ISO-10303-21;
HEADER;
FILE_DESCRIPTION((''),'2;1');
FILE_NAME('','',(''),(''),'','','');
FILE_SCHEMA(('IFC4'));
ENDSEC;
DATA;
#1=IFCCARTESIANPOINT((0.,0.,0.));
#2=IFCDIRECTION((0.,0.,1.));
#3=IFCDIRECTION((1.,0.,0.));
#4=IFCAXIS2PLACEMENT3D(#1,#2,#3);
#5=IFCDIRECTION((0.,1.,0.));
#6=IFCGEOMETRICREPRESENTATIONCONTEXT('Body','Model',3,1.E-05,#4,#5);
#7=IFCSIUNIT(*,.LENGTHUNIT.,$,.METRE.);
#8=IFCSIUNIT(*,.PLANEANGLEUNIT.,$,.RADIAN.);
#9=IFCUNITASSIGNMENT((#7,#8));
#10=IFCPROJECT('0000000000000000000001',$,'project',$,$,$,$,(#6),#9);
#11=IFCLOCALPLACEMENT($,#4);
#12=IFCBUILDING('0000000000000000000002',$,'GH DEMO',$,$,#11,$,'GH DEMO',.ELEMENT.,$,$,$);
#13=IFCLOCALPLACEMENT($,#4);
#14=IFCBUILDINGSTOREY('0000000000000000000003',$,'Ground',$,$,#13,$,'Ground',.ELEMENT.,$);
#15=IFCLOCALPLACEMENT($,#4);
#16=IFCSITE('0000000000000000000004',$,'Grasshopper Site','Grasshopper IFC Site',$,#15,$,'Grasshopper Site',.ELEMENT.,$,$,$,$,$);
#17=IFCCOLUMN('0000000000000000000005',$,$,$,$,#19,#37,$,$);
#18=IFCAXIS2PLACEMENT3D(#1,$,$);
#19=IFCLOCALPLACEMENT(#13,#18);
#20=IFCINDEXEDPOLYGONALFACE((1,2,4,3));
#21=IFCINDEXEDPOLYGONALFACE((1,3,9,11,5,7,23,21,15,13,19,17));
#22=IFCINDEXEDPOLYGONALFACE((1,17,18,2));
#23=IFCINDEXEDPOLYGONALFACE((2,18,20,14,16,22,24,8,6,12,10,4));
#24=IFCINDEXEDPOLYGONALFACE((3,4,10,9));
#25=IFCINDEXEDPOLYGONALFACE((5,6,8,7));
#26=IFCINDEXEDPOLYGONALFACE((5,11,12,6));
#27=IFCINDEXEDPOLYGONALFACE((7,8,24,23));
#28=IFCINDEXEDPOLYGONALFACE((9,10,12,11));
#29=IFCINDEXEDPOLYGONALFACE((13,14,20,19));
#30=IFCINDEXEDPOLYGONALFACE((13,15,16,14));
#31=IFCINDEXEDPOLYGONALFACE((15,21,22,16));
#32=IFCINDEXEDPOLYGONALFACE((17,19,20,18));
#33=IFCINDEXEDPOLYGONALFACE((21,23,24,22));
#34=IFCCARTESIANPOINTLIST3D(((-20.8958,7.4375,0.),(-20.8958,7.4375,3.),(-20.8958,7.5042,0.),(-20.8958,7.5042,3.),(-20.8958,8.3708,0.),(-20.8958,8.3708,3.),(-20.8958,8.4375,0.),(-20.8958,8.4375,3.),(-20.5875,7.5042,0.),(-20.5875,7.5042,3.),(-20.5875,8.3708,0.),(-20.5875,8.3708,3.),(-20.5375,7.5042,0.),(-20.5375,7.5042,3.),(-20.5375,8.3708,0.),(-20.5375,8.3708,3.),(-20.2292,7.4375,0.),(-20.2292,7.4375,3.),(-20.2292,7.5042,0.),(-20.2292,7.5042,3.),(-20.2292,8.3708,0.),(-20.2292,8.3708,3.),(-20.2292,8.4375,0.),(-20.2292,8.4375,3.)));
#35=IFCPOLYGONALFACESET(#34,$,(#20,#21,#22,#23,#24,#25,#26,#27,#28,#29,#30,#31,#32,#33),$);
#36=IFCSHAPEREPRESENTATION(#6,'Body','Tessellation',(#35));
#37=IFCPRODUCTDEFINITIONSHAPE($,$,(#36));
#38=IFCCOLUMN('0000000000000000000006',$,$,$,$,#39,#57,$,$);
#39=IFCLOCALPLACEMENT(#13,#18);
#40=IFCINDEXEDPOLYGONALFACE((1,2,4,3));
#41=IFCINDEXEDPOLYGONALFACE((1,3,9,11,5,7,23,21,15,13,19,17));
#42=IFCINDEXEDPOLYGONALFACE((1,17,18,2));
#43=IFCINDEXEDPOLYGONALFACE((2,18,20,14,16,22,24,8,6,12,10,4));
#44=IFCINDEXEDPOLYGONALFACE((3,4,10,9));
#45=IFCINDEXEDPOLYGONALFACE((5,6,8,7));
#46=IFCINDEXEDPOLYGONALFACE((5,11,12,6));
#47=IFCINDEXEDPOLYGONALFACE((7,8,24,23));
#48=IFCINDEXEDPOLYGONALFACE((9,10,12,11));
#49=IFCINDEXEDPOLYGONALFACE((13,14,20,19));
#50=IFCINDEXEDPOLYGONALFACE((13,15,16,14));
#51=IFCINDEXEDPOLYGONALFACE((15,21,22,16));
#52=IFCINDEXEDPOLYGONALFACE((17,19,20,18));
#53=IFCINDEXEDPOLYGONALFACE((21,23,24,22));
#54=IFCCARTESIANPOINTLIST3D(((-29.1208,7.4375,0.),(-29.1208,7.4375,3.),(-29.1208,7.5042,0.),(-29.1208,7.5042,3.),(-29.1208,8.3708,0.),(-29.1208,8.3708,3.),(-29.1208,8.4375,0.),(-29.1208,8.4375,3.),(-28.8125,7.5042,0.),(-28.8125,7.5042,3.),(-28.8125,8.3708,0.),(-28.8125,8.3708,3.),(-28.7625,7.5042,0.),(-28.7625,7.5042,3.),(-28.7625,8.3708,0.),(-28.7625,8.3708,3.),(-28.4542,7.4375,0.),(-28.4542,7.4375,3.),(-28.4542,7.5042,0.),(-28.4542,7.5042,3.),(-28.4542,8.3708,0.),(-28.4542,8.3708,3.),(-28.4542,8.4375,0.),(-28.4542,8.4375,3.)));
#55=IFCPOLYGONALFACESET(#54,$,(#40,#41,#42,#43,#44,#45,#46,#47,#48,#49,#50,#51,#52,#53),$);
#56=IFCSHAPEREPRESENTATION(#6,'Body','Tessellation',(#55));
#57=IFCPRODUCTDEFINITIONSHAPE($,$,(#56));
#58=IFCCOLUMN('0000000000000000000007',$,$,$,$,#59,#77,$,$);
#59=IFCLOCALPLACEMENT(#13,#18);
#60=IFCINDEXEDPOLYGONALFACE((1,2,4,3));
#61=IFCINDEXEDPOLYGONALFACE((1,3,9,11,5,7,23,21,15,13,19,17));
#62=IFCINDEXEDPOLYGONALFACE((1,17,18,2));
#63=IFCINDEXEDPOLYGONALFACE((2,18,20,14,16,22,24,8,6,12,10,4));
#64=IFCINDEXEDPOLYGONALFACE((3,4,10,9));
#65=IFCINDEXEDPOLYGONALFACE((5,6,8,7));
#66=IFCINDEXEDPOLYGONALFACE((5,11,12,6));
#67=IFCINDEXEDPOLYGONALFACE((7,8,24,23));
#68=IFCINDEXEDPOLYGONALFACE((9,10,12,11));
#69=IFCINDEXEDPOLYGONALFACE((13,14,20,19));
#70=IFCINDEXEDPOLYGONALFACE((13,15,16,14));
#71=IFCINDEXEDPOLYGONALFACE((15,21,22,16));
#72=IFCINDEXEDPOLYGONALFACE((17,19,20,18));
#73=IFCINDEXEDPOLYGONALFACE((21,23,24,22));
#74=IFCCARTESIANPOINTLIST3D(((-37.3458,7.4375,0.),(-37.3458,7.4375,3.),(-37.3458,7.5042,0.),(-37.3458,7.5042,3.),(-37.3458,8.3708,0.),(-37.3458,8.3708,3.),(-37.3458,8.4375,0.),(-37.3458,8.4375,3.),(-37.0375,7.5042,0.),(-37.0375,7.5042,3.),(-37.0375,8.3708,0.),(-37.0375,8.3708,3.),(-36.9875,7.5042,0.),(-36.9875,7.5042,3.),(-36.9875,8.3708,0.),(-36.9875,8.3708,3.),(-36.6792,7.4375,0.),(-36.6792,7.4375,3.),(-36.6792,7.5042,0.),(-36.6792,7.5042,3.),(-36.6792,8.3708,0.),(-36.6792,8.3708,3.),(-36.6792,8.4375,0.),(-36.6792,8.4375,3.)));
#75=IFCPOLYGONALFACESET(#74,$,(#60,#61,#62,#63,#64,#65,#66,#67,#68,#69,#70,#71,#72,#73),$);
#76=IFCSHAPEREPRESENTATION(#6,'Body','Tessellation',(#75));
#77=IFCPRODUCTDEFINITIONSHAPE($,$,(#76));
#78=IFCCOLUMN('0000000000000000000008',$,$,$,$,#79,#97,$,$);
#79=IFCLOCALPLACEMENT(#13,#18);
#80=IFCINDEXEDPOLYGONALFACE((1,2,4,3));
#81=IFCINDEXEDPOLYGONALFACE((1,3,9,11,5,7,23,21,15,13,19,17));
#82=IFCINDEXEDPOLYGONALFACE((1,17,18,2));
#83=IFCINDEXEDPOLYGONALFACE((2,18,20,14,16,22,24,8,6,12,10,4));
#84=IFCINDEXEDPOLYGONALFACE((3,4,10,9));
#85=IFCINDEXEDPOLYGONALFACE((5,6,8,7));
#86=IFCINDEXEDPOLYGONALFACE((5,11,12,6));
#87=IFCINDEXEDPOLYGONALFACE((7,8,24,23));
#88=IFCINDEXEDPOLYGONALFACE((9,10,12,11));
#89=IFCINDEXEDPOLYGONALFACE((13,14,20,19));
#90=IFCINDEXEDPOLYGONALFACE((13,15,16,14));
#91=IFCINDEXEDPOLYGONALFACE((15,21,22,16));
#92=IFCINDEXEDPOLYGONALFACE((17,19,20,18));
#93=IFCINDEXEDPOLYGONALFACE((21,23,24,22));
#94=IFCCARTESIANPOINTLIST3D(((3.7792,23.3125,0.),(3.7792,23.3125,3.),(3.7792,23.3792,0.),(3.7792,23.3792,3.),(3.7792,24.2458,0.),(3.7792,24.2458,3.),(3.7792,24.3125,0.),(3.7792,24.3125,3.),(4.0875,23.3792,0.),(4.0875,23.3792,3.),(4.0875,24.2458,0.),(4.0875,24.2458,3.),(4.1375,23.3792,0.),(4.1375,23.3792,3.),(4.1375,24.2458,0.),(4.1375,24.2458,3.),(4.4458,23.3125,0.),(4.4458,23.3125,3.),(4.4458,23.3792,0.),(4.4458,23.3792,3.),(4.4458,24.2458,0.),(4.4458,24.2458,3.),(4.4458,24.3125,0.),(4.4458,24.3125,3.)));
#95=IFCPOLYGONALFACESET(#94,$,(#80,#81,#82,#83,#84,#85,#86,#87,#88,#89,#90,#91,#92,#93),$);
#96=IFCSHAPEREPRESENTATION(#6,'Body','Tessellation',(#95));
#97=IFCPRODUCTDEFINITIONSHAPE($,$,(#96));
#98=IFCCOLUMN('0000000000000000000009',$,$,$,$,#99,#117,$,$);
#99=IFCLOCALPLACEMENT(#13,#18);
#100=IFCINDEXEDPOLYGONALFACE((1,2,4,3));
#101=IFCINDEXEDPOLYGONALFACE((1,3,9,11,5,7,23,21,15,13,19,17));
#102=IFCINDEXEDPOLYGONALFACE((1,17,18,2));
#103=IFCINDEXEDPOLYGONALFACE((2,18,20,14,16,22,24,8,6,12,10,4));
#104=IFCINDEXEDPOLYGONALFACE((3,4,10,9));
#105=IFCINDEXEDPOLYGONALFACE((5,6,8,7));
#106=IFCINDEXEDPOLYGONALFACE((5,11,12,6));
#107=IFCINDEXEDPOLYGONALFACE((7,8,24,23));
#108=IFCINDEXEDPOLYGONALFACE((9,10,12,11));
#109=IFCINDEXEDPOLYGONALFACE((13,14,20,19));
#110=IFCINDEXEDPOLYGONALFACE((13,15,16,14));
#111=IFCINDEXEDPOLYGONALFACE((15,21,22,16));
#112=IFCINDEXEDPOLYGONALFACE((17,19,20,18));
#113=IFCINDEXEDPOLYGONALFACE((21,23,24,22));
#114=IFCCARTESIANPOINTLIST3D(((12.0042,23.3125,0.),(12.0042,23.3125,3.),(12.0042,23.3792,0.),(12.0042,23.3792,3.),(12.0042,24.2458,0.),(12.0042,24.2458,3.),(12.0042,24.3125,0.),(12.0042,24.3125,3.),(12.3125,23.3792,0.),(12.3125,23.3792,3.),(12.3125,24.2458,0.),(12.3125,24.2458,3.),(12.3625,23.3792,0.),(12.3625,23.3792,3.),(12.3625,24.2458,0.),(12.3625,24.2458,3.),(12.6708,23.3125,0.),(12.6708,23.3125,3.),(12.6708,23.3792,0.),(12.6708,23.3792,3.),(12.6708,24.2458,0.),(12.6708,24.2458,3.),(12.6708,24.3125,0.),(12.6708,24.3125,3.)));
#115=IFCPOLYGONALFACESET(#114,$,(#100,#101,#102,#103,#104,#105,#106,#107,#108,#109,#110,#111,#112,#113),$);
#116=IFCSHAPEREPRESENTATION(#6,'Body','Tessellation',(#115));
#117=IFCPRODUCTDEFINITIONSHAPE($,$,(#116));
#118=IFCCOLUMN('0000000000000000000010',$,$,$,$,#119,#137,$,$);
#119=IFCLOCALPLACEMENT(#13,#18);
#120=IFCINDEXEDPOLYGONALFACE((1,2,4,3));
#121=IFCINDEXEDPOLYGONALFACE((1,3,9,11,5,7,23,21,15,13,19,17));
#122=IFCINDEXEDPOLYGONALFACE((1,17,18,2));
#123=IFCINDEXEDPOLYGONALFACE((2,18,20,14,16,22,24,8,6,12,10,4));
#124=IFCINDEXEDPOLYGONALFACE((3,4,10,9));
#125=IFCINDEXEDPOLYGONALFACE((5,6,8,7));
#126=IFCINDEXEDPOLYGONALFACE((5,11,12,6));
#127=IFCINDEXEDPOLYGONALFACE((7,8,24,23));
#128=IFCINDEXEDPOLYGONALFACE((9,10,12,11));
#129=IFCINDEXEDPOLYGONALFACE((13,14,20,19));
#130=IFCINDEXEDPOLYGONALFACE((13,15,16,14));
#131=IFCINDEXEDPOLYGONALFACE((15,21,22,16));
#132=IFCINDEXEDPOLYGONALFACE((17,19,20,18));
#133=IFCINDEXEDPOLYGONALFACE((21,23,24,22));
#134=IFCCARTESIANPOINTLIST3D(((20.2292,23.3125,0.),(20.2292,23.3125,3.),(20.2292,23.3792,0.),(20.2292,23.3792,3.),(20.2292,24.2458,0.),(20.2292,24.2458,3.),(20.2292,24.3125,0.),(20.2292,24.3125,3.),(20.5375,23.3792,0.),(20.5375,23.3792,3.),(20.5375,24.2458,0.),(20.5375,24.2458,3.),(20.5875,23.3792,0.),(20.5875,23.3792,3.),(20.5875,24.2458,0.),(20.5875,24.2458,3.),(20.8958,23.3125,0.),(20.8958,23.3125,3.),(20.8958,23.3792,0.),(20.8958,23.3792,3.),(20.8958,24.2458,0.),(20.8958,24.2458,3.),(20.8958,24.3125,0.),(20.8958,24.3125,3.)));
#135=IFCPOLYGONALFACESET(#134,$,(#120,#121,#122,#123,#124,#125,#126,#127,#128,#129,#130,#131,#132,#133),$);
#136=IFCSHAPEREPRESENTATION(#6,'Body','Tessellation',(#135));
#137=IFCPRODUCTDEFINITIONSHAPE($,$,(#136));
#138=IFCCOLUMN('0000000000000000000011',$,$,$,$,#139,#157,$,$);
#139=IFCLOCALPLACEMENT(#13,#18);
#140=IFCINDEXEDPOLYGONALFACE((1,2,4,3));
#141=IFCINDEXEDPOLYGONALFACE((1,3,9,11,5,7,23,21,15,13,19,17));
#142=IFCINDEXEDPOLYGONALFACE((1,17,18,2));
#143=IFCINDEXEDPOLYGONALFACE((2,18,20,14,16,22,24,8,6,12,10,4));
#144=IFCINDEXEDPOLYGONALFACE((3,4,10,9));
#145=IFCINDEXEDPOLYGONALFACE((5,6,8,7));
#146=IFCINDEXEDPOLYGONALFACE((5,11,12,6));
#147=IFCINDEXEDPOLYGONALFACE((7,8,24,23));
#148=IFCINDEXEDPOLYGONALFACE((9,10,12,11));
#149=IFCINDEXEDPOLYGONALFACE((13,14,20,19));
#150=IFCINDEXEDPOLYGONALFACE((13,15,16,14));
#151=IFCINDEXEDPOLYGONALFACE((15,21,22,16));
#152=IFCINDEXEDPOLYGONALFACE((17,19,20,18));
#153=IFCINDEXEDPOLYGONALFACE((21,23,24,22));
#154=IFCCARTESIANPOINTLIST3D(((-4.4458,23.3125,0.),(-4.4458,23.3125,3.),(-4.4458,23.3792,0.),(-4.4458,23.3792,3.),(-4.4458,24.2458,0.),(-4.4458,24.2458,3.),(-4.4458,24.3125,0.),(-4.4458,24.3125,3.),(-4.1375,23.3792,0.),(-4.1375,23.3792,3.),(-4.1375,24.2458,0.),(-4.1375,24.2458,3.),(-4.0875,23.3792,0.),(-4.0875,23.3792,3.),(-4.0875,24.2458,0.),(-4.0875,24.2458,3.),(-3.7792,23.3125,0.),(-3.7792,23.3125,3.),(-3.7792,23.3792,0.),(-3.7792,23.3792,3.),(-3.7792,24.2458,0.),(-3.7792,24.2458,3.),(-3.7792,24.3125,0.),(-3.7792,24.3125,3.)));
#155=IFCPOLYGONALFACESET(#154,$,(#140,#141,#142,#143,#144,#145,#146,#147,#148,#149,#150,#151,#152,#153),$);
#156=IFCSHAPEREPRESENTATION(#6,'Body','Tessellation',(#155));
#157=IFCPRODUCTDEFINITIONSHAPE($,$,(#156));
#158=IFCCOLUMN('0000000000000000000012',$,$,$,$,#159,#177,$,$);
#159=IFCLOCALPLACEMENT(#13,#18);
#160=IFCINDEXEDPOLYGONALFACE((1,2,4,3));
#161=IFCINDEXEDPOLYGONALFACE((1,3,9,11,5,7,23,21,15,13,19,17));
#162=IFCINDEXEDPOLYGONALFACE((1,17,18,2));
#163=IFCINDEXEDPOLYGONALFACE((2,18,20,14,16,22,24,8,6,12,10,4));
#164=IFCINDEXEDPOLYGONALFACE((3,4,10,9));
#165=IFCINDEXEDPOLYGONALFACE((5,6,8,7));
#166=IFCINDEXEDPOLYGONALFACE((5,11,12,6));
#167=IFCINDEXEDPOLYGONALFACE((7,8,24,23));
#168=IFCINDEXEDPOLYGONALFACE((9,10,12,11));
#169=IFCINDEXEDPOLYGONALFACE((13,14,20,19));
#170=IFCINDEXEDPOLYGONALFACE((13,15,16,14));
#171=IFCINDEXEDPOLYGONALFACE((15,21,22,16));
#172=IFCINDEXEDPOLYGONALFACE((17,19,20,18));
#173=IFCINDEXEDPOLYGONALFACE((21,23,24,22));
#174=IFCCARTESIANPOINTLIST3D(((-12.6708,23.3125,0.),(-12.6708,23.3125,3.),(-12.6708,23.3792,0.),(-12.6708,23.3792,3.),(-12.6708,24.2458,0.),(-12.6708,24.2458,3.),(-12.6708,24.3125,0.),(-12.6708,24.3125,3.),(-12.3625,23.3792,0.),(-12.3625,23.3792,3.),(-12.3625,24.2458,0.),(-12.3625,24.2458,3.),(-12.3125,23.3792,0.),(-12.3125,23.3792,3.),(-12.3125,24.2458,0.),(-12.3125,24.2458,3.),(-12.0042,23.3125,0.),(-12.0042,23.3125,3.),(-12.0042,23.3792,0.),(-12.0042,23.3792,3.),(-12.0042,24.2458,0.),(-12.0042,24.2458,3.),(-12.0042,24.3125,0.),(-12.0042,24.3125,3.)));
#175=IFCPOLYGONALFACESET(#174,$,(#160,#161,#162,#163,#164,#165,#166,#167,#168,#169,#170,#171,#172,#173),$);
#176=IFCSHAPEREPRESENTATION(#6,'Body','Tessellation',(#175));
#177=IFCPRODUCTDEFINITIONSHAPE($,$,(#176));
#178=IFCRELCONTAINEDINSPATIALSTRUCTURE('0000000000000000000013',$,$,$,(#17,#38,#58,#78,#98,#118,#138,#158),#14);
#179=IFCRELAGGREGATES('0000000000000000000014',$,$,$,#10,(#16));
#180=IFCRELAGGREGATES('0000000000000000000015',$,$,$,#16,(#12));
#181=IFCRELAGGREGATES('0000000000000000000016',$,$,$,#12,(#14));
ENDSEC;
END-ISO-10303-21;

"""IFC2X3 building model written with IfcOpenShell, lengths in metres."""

from ifc_helpers import new_model, si_unit, direction, origin_with_axes, place, context, project, spatial, polyline, outline, extrude, source, transform, mapped, element, save


model = new_model("IFC2X3")

# Units and contexts
model_context = context("Model", 3, precision=1e-05, world=origin_with_axes(), true_north=direction((0.0, 1.0, 0.0)), identifier="Body")
ifc_project = project(units=[si_unit("LENGTHUNIT", "METRE"), si_unit("PLANEANGLEUNIT", "RADIAN")], contexts=[model_context])

# Site, building, storey
site_placement = place(None, origin_with_axes())
site = spatial("IfcSite", under=ifc_project, at=site_placement, Name="Grasshopper Site", Description="Grasshopper IFC Site", LongName="Grasshopper Site", CompositionType="ELEMENT")
building_placement = place(None, origin_with_axes())
building = spatial("IfcBuilding", under=site, at=building_placement, Name="GH DEMO", LongName="GH DEMO", CompositionType="ELEMENT")
storey_placement = place(None, origin_with_axes())
storey = spatial("IfcBuildingStorey", under=building, at=storey_placement, Name="Ground", LongName="Ground", CompositionType="ELEMENT")

# Columns
shared_shape_1 = source(origin_with_axes(), model_context, "Body", "SweptSolid", [
    extrude(outline(polyline([(0.025, -0.4333), (0.025, 0.4333), (0.3333, 0.4333), (0.3333, 0.5), (-0.3333, 0.5), (-0.3333, 0.4333), (-0.025, 0.4333), (-0.025, -0.4333), (-0.3333, -0.4333), (-0.3333, -0.5), (0.3333, -0.5), (0.3333, -0.4333), (0.025, -0.4333)])), origin_with_axes(), (0.0, 0.0, 1.0), 3.0),
])
column_1_placement = place(None, origin_with_axes())
element("IfcColumn", 1, at=column_1_placement, inside=storey, context=model_context, shape_type="MappedRepresentation", body=[
    mapped(shared_shape_1, transform((-20.5625, 7.9375, 0.0), x_axis=(1.0, 0.0, 0.0), y_axis=(0.0, 1.0, 0.0), z_axis=(0.0, 0.0, 1.0), scale=1.0)),
])
shared_shape_2 = source(origin_with_axes(), model_context, "Body", "SweptSolid", [
    extrude(outline(polyline([(0.025, -0.4333), (0.025, 0.4333), (0.3333, 0.4333), (0.3333, 0.5), (-0.3333, 0.5), (-0.3333, 0.4333), (-0.025, 0.4333), (-0.025, -0.4333), (-0.3333, -0.4333), (-0.3333, -0.5), (0.3333, -0.5), (0.3333, -0.4333), (0.025, -0.4333)])), origin_with_axes(), (0.0, 0.0, 1.0), 3.0),
])
column_2_placement = place(None, origin_with_axes())
element("IfcColumn", 2, at=column_2_placement, inside=storey, context=model_context, shape_type="MappedRepresentation", body=[
    mapped(shared_shape_2, transform((-28.7875, 7.9375, 0.0), x_axis=(1.0, 0.0, 0.0), y_axis=(0.0, 1.0, 0.0), z_axis=(0.0, 0.0, 1.0), scale=1.0)),
])
shared_shape_3 = source(origin_with_axes(), model_context, "Body", "SweptSolid", [
    extrude(outline(polyline([(0.025, -0.4333), (0.025, 0.4333), (0.3333, 0.4333), (0.3333, 0.5), (-0.3333, 0.5), (-0.3333, 0.4333), (-0.025, 0.4333), (-0.025, -0.4333), (-0.3333, -0.4333), (-0.3333, -0.5), (0.3333, -0.5), (0.3333, -0.4333), (0.025, -0.4333)])), origin_with_axes(), (0.0, 0.0, 1.0), 3.0),
])
column_3_placement = place(None, origin_with_axes())
element("IfcColumn", 3, at=column_3_placement, inside=storey, context=model_context, shape_type="MappedRepresentation", body=[
    mapped(shared_shape_3, transform((-37.0125, 7.9375, 0.0), x_axis=(1.0, 0.0, 0.0), y_axis=(0.0, 1.0, 0.0), z_axis=(0.0, 0.0, 1.0), scale=1.0)),
])
shared_shape_4 = source(origin_with_axes(), model_context, "Body", "SweptSolid", [
    extrude(outline(polyline([(0.025, -0.4333), (0.025, 0.4333), (0.3333, 0.4333), (0.3333, 0.5), (-0.3333, 0.5), (-0.3333, 0.4333), (-0.025, 0.4333), (-0.025, -0.4333), (-0.3333, -0.4333), (-0.3333, -0.5), (0.3333, -0.5), (0.3333, -0.4333), (0.025, -0.4333)])), origin_with_axes(), (0.0, 0.0, 1.0), 3.0),
])
column_4_placement = place(None, origin_with_axes())
element("IfcColumn", 4, at=column_4_placement, inside=storey, context=model_context, shape_type="MappedRepresentation", body=[
    mapped(shared_shape_4, transform((4.1125, 23.8125, 0.0), x_axis=(1.0, 0.0, 0.0), y_axis=(0.0, 1.0, 0.0), z_axis=(0.0, 0.0, 1.0), scale=1.0)),
])
shared_shape_5 = source(origin_with_axes(), model_context, "Body", "SweptSolid", [
    extrude(outline(polyline([(0.025, -0.4333), (0.025, 0.4333), (0.3333, 0.4333), (0.3333, 0.5), (-0.3333, 0.5), (-0.3333, 0.4333), (-0.025, 0.4333), (-0.025, -0.4333), (-0.3333, -0.4333), (-0.3333, -0.5), (0.3333, -0.5), (0.3333, -0.4333), (0.025, -0.4333)])), origin_with_axes(), (0.0, 0.0, 1.0), 3.0),
])
column_5_placement = place(None, origin_with_axes())
element("IfcColumn", 5, at=column_5_placement, inside=storey, context=model_context, shape_type="MappedRepresentation", body=[
    mapped(shared_shape_5, transform((12.3375, 23.8125, 0.0), x_axis=(1.0, 0.0, 0.0), y_axis=(0.0, 1.0, 0.0), z_axis=(0.0, 0.0, 1.0), scale=1.0)),
])
shared_shape_6 = source(origin_with_axes(), model_context, "Body", "SweptSolid", [
    extrude(outline(polyline([(0.025, -0.4333), (0.025, 0.4333), (0.3333, 0.4333), (0.3333, 0.5), (-0.3333, 0.5), (-0.3333, 0.4333), (-0.025, 0.4333), (-0.025, -0.4333), (-0.3333, -0.4333), (-0.3333, -0.5), (0.3333, -0.5), (0.3333, -0.4333), (0.025, -0.4333)])), origin_with_axes(), (0.0, 0.0, 1.0), 3.0),
])
column_6_placement = place(None, origin_with_axes())
element("IfcColumn", 6, at=column_6_placement, inside=storey, context=model_context, shape_type="MappedRepresentation", body=[
    mapped(shared_shape_6, transform((20.5625, 23.8125, 0.0), x_axis=(1.0, 0.0, 0.0), y_axis=(0.0, 1.0, 0.0), z_axis=(0.0, 0.0, 1.0), scale=1.0)),
])
shared_shape_7 = source(origin_with_axes(), model_context, "Body", "SweptSolid", [
    extrude(outline(polyline([(0.025, -0.4333), (0.025, 0.4333), (0.3333, 0.4333), (0.3333, 0.5), (-0.3333, 0.5), (-0.3333, 0.4333), (-0.025, 0.4333), (-0.025, -0.4333), (-0.3333, -0.4333), (-0.3333, -0.5), (0.3333, -0.5), (0.3333, -0.4333), (0.025, -0.4333)])), origin_with_axes(), (0.0, 0.0, 1.0), 3.0),
])
column_7_placement = place(None, origin_with_axes())
element("IfcColumn", 7, at=column_7_placement, inside=storey, context=model_context, shape_type="MappedRepresentation", body=[
    mapped(shared_shape_7, transform((-4.1125, 23.8125, 0.0), x_axis=(1.0, 0.0, 0.0), y_axis=(0.0, 1.0, 0.0), z_axis=(0.0, 0.0, 1.0), scale=1.0)),
])
shared_shape_8 = source(origin_with_axes(), model_context, "Body", "SweptSolid", [
    extrude(outline(polyline([(0.025, -0.4333), (0.025, 0.4333), (0.3333, 0.4333), (0.3333, 0.5), (-0.3333, 0.5), (-0.3333, 0.4333), (-0.025, 0.4333), (-0.025, -0.4333), (-0.3333, -0.4333), (-0.3333, -0.5), (0.3333, -0.5), (0.3333, -0.4333), (0.025, -0.4333)])), origin_with_axes(), (0.0, 0.0, 1.0), 3.0),
])
column_8_placement = place(None, origin_with_axes())
element("IfcColumn", 8, at=column_8_placement, inside=storey, context=model_context, shape_type="MappedRepresentation", body=[
    mapped(shared_shape_8, transform((-12.3375, 23.8125, 0.0), x_axis=(1.0, 0.0, 0.0), y_axis=(0.0, 1.0, 0.0), z_axis=(0.0, 0.0, 1.0), scale=1.0)),
])

save(model, "model.ifc")
